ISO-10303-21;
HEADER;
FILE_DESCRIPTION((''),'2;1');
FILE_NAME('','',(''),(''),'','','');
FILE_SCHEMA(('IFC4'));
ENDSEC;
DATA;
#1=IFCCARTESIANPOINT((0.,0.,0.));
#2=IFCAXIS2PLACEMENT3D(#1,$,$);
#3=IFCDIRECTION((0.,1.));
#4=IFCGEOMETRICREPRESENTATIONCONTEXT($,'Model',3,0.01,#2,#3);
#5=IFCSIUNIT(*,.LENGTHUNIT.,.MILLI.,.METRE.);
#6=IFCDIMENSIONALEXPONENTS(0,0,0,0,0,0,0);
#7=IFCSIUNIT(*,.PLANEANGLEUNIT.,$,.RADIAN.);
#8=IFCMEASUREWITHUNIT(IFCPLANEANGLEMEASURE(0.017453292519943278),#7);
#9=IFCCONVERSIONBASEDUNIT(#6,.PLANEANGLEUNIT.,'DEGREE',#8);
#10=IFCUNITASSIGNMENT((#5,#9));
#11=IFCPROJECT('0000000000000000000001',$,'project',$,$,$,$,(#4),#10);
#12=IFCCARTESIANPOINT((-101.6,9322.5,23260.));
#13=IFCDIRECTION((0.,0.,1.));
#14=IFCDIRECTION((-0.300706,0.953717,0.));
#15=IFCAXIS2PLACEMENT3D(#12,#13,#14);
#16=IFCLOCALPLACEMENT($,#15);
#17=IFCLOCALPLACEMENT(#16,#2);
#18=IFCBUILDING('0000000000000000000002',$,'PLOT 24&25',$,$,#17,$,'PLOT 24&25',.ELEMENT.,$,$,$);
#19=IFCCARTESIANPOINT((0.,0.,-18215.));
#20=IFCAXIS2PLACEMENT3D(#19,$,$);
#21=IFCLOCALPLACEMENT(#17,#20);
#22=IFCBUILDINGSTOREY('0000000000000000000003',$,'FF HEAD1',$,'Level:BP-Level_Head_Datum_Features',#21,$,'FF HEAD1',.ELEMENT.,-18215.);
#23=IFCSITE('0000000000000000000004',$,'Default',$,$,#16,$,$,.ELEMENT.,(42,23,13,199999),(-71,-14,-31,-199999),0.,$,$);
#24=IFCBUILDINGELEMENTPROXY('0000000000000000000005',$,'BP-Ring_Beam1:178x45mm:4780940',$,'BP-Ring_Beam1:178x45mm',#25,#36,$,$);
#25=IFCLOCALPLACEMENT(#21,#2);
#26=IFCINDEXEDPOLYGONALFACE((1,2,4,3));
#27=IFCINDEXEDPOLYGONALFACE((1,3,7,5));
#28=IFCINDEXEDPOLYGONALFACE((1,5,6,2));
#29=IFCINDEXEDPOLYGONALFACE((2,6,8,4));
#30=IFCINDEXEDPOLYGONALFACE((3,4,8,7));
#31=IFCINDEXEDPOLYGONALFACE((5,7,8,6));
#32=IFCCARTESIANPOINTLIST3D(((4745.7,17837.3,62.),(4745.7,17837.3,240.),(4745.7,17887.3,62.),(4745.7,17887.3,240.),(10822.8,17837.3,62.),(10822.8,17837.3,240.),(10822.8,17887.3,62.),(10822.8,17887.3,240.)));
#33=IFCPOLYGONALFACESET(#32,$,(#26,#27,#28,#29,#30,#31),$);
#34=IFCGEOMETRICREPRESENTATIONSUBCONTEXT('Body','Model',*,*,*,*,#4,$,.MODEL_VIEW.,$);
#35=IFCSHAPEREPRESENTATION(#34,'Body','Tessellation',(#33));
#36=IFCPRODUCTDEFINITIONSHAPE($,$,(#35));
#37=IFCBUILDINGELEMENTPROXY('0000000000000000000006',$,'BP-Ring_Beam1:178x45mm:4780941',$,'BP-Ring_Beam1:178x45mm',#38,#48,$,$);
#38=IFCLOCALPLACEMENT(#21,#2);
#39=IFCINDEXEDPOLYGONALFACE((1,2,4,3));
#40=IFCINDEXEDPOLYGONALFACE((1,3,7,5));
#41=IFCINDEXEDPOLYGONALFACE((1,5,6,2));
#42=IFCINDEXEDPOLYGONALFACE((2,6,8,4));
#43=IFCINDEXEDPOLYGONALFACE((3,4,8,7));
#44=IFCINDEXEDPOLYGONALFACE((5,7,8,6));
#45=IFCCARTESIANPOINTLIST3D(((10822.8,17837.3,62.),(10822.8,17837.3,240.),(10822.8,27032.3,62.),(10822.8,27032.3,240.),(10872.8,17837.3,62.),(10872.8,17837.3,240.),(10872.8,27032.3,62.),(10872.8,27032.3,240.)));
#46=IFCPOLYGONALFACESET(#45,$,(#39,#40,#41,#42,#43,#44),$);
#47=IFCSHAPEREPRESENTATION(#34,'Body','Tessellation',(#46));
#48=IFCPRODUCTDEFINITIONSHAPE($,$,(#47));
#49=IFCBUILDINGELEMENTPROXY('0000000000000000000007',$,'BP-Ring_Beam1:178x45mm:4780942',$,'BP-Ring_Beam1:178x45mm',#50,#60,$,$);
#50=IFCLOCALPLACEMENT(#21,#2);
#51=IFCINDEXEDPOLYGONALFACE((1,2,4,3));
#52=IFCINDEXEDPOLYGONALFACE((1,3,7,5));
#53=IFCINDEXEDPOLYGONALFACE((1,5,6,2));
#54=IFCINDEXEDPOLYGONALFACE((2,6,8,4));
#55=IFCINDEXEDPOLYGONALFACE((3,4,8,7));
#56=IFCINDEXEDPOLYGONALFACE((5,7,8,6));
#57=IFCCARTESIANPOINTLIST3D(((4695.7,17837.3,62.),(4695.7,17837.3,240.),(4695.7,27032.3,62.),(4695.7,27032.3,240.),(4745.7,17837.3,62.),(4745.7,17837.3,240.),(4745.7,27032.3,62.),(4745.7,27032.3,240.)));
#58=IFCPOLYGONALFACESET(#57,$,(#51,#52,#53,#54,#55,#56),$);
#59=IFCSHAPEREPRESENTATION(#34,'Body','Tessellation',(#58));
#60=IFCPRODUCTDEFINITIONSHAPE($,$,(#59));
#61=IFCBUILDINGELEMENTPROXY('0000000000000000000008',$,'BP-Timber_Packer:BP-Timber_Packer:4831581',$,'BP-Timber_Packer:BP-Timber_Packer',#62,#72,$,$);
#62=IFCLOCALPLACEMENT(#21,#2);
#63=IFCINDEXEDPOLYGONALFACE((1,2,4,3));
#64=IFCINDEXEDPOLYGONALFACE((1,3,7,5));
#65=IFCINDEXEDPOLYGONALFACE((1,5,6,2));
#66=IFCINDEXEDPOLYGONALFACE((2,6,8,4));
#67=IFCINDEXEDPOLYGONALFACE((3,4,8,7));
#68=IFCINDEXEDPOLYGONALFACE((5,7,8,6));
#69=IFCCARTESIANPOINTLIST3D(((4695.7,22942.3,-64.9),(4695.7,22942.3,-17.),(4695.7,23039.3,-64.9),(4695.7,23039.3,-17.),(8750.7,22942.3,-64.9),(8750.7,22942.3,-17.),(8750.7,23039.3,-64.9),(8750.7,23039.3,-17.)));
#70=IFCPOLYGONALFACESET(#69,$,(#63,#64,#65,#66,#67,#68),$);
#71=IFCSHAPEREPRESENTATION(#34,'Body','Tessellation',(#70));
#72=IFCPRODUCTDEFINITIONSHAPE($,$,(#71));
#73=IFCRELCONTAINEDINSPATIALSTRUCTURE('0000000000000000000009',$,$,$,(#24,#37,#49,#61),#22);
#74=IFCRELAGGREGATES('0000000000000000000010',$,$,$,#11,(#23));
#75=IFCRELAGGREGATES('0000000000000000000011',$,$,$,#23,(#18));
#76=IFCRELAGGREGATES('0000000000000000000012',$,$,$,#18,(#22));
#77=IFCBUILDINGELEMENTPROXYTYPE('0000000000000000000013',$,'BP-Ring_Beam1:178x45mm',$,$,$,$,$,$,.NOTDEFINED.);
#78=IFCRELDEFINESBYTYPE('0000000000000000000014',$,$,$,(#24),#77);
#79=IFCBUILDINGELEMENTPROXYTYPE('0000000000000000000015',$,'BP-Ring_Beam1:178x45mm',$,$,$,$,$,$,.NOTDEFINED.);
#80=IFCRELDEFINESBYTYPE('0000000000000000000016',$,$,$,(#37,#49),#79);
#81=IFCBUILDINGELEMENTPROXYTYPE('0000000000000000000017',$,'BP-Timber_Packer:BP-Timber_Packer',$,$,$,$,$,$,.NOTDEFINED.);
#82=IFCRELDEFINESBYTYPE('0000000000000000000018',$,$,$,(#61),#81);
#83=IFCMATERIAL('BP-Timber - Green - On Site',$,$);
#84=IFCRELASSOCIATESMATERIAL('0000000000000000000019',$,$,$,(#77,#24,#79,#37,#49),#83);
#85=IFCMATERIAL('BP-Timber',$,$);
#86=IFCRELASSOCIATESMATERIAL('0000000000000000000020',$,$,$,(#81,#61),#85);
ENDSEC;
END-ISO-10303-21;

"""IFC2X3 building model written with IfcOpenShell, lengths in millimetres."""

from ifc_helpers import new_model, entity, si_unit, converted_unit, direction, frame, origin, origin_2d_with_axis, place, context, subcontext, project, spatial, rectangle, extrude, source, transform, mapped, material, type_object, type_shapes, element, save


model = new_model("IFC2X3")

# Units and contexts
model_context = context("Model", 3, precision=0.01, world=origin(), true_north=direction((0.0, 1.0)))
body_context = subcontext(model_context, "Body", "Model", "MODEL_VIEW")
ifc_project = project(units=[si_unit("LENGTHUNIT", "METRE", prefix="MILLI"), converted_unit("PLANEANGLEUNIT", "DEGREE", entity("IfcPlaneAngleMeasure", 0.017453292519943278), si_unit("PLANEANGLEUNIT", "RADIAN"), dimensions=[0, 0, 0, 0, 0, 0, 0])], contexts=[model_context])

# Site, building, storey
site_placement = place(None, frame((-101.6, 9322.5, 23260.0), z_axis=(0.0, 0.0, 1.0), x_axis=(-0.300706, 0.953717, 0.0)))
site = spatial("IfcSite", under=ifc_project, at=site_placement, Name="Default", CompositionType="ELEMENT", RefLatitude=(42, 23, 13, 199999), RefLongitude=(-71, -14, -31, -199999), RefElevation=0.0)
building_placement = place(site_placement, origin())
building = spatial("IfcBuilding", under=site, at=building_placement, Name="PLOT 24&25", LongName="PLOT 24&25", CompositionType="ELEMENT")
storey_placement = place(building_placement, frame((0.0, 0.0, -18215.0)))
storey = spatial("IfcBuildingStorey", under=building, at=storey_placement, Name="FF HEAD1", ObjectType="Level:BP-Level_Head_Datum_Features", LongName="FF HEAD1", CompositionType="ELEMENT", Elevation=-18215.0)

# Building element proxies
ifc_material_1 = material(Name="BP-Timber")
ifc_material_2 = material(Name="BP-Timber - Green - On Site")
building_element_proxy_type_1 = type_object("IfcBuildingElementProxyType", Name="BP-Ring_Beam1:178x45mm", PredefinedType="NOTDEFINED", material=ifc_material_2)
shared_shape_1 = source(origin(), body_context, "Body", "SweptSolid", [
    extrude(rectangle(XDim=50.0, YDim=6077.2, at=origin_2d_with_axis()), frame((0.0, 25.0, -178.0), z_axis=(0.0, 0.0, 1.0), x_axis=(0.0, 1.0, 0.0)), (0.0, 0.0, 1.0), 178.0),
])
type_shapes(building_element_proxy_type_1, [shared_shape_1])
for number, where, z_axis, x_axis, name in (
    (1, (7784.3, 17887.3, 240.0), (0.0, 0.0, 1.0), (-1.0, 0.0, 0.0), "BP-Ring_Beam1:178x45mm:4780940"),
):
    element("IfcBuildingElementProxy", number, at=place(storey_placement, frame(where, z_axis=z_axis, x_axis=x_axis)), inside=storey, type_object=building_element_proxy_type_1, material=ifc_material_2, Name=name, ObjectType="BP-Ring_Beam1:178x45mm", context=body_context, shape_type="MappedRepresentation", body=[
        mapped(shared_shape_1, transform((0.0, 0.0, 0.0), scale=1.0)),
    ])
building_element_proxy_type_2 = type_object("IfcBuildingElementProxyType", Name="BP-Ring_Beam1:178x45mm", PredefinedType="NOTDEFINED", material=ifc_material_2)
shared_shape_2 = source(origin(), body_context, "Body", "SweptSolid", [
    extrude(rectangle(XDim=50.0, YDim=9195.0, at=origin_2d_with_axis()), frame((0.0, 25.0, -178.0), z_axis=(0.0, 0.0, 1.0), x_axis=(0.0, 1.0, 0.0)), (0.0, 0.0, 1.0), 178.0),
])
type_shapes(building_element_proxy_type_2, [shared_shape_2])
for number, where, z_axis, x_axis, name in (
    (2, (10822.8, 22434.8, 240.0), (0.0, 0.0, 1.0), (0.0, -1.0, 0.0), "BP-Ring_Beam1:178x45mm:4780941"),
    (3, (4695.7, 22434.8, 240.0), (0.0, 0.0, 1.0), (0.0, -1.0, 0.0), "BP-Ring_Beam1:178x45mm:4780942"),
):
    element("IfcBuildingElementProxy", number, at=place(storey_placement, frame(where, z_axis=z_axis, x_axis=x_axis)), inside=storey, type_object=building_element_proxy_type_2, material=ifc_material_2, Name=name, ObjectType="BP-Ring_Beam1:178x45mm", context=body_context, shape_type="MappedRepresentation", body=[
        mapped(shared_shape_2, transform((0.0, 0.0, 0.0), scale=1.0)),
    ])
building_element_proxy_type_3 = type_object("IfcBuildingElementProxyType", Name="BP-Timber_Packer:BP-Timber_Packer", PredefinedType="NOTDEFINED", material=ifc_material_1)
shared_shape_3 = source(origin(), body_context, "Body", "SweptSolid", [
    extrude(rectangle(XDim=97.0, YDim=4055.0, at=origin_2d_with_axis()), frame((0.0, 0.0, 0.0), z_axis=(0.0, 0.0, 1.0), x_axis=(0.0, 1.0, 0.0)), (0.0, 0.0, 1.0), 47.9),
])
type_shapes(building_element_proxy_type_3, [shared_shape_3])
proxy_1_placement = place(storey_placement, frame((6723.2, 22990.8, -64.9), z_axis=(0.0, 0.0, 1.0), x_axis=(-1.0, 0.0, 0.0)))
element("IfcBuildingElementProxy", 4, at=proxy_1_placement, inside=storey, type_object=building_element_proxy_type_3, material=ifc_material_1, Name="BP-Timber_Packer:BP-Timber_Packer:4831581", ObjectType="BP-Timber_Packer:BP-Timber_Packer", context=body_context, shape_type="MappedRepresentation", body=[
    mapped(shared_shape_3, transform((0.0, 0.0, 0.0), scale=1.0)),
])

save(model, "model.ifc")
